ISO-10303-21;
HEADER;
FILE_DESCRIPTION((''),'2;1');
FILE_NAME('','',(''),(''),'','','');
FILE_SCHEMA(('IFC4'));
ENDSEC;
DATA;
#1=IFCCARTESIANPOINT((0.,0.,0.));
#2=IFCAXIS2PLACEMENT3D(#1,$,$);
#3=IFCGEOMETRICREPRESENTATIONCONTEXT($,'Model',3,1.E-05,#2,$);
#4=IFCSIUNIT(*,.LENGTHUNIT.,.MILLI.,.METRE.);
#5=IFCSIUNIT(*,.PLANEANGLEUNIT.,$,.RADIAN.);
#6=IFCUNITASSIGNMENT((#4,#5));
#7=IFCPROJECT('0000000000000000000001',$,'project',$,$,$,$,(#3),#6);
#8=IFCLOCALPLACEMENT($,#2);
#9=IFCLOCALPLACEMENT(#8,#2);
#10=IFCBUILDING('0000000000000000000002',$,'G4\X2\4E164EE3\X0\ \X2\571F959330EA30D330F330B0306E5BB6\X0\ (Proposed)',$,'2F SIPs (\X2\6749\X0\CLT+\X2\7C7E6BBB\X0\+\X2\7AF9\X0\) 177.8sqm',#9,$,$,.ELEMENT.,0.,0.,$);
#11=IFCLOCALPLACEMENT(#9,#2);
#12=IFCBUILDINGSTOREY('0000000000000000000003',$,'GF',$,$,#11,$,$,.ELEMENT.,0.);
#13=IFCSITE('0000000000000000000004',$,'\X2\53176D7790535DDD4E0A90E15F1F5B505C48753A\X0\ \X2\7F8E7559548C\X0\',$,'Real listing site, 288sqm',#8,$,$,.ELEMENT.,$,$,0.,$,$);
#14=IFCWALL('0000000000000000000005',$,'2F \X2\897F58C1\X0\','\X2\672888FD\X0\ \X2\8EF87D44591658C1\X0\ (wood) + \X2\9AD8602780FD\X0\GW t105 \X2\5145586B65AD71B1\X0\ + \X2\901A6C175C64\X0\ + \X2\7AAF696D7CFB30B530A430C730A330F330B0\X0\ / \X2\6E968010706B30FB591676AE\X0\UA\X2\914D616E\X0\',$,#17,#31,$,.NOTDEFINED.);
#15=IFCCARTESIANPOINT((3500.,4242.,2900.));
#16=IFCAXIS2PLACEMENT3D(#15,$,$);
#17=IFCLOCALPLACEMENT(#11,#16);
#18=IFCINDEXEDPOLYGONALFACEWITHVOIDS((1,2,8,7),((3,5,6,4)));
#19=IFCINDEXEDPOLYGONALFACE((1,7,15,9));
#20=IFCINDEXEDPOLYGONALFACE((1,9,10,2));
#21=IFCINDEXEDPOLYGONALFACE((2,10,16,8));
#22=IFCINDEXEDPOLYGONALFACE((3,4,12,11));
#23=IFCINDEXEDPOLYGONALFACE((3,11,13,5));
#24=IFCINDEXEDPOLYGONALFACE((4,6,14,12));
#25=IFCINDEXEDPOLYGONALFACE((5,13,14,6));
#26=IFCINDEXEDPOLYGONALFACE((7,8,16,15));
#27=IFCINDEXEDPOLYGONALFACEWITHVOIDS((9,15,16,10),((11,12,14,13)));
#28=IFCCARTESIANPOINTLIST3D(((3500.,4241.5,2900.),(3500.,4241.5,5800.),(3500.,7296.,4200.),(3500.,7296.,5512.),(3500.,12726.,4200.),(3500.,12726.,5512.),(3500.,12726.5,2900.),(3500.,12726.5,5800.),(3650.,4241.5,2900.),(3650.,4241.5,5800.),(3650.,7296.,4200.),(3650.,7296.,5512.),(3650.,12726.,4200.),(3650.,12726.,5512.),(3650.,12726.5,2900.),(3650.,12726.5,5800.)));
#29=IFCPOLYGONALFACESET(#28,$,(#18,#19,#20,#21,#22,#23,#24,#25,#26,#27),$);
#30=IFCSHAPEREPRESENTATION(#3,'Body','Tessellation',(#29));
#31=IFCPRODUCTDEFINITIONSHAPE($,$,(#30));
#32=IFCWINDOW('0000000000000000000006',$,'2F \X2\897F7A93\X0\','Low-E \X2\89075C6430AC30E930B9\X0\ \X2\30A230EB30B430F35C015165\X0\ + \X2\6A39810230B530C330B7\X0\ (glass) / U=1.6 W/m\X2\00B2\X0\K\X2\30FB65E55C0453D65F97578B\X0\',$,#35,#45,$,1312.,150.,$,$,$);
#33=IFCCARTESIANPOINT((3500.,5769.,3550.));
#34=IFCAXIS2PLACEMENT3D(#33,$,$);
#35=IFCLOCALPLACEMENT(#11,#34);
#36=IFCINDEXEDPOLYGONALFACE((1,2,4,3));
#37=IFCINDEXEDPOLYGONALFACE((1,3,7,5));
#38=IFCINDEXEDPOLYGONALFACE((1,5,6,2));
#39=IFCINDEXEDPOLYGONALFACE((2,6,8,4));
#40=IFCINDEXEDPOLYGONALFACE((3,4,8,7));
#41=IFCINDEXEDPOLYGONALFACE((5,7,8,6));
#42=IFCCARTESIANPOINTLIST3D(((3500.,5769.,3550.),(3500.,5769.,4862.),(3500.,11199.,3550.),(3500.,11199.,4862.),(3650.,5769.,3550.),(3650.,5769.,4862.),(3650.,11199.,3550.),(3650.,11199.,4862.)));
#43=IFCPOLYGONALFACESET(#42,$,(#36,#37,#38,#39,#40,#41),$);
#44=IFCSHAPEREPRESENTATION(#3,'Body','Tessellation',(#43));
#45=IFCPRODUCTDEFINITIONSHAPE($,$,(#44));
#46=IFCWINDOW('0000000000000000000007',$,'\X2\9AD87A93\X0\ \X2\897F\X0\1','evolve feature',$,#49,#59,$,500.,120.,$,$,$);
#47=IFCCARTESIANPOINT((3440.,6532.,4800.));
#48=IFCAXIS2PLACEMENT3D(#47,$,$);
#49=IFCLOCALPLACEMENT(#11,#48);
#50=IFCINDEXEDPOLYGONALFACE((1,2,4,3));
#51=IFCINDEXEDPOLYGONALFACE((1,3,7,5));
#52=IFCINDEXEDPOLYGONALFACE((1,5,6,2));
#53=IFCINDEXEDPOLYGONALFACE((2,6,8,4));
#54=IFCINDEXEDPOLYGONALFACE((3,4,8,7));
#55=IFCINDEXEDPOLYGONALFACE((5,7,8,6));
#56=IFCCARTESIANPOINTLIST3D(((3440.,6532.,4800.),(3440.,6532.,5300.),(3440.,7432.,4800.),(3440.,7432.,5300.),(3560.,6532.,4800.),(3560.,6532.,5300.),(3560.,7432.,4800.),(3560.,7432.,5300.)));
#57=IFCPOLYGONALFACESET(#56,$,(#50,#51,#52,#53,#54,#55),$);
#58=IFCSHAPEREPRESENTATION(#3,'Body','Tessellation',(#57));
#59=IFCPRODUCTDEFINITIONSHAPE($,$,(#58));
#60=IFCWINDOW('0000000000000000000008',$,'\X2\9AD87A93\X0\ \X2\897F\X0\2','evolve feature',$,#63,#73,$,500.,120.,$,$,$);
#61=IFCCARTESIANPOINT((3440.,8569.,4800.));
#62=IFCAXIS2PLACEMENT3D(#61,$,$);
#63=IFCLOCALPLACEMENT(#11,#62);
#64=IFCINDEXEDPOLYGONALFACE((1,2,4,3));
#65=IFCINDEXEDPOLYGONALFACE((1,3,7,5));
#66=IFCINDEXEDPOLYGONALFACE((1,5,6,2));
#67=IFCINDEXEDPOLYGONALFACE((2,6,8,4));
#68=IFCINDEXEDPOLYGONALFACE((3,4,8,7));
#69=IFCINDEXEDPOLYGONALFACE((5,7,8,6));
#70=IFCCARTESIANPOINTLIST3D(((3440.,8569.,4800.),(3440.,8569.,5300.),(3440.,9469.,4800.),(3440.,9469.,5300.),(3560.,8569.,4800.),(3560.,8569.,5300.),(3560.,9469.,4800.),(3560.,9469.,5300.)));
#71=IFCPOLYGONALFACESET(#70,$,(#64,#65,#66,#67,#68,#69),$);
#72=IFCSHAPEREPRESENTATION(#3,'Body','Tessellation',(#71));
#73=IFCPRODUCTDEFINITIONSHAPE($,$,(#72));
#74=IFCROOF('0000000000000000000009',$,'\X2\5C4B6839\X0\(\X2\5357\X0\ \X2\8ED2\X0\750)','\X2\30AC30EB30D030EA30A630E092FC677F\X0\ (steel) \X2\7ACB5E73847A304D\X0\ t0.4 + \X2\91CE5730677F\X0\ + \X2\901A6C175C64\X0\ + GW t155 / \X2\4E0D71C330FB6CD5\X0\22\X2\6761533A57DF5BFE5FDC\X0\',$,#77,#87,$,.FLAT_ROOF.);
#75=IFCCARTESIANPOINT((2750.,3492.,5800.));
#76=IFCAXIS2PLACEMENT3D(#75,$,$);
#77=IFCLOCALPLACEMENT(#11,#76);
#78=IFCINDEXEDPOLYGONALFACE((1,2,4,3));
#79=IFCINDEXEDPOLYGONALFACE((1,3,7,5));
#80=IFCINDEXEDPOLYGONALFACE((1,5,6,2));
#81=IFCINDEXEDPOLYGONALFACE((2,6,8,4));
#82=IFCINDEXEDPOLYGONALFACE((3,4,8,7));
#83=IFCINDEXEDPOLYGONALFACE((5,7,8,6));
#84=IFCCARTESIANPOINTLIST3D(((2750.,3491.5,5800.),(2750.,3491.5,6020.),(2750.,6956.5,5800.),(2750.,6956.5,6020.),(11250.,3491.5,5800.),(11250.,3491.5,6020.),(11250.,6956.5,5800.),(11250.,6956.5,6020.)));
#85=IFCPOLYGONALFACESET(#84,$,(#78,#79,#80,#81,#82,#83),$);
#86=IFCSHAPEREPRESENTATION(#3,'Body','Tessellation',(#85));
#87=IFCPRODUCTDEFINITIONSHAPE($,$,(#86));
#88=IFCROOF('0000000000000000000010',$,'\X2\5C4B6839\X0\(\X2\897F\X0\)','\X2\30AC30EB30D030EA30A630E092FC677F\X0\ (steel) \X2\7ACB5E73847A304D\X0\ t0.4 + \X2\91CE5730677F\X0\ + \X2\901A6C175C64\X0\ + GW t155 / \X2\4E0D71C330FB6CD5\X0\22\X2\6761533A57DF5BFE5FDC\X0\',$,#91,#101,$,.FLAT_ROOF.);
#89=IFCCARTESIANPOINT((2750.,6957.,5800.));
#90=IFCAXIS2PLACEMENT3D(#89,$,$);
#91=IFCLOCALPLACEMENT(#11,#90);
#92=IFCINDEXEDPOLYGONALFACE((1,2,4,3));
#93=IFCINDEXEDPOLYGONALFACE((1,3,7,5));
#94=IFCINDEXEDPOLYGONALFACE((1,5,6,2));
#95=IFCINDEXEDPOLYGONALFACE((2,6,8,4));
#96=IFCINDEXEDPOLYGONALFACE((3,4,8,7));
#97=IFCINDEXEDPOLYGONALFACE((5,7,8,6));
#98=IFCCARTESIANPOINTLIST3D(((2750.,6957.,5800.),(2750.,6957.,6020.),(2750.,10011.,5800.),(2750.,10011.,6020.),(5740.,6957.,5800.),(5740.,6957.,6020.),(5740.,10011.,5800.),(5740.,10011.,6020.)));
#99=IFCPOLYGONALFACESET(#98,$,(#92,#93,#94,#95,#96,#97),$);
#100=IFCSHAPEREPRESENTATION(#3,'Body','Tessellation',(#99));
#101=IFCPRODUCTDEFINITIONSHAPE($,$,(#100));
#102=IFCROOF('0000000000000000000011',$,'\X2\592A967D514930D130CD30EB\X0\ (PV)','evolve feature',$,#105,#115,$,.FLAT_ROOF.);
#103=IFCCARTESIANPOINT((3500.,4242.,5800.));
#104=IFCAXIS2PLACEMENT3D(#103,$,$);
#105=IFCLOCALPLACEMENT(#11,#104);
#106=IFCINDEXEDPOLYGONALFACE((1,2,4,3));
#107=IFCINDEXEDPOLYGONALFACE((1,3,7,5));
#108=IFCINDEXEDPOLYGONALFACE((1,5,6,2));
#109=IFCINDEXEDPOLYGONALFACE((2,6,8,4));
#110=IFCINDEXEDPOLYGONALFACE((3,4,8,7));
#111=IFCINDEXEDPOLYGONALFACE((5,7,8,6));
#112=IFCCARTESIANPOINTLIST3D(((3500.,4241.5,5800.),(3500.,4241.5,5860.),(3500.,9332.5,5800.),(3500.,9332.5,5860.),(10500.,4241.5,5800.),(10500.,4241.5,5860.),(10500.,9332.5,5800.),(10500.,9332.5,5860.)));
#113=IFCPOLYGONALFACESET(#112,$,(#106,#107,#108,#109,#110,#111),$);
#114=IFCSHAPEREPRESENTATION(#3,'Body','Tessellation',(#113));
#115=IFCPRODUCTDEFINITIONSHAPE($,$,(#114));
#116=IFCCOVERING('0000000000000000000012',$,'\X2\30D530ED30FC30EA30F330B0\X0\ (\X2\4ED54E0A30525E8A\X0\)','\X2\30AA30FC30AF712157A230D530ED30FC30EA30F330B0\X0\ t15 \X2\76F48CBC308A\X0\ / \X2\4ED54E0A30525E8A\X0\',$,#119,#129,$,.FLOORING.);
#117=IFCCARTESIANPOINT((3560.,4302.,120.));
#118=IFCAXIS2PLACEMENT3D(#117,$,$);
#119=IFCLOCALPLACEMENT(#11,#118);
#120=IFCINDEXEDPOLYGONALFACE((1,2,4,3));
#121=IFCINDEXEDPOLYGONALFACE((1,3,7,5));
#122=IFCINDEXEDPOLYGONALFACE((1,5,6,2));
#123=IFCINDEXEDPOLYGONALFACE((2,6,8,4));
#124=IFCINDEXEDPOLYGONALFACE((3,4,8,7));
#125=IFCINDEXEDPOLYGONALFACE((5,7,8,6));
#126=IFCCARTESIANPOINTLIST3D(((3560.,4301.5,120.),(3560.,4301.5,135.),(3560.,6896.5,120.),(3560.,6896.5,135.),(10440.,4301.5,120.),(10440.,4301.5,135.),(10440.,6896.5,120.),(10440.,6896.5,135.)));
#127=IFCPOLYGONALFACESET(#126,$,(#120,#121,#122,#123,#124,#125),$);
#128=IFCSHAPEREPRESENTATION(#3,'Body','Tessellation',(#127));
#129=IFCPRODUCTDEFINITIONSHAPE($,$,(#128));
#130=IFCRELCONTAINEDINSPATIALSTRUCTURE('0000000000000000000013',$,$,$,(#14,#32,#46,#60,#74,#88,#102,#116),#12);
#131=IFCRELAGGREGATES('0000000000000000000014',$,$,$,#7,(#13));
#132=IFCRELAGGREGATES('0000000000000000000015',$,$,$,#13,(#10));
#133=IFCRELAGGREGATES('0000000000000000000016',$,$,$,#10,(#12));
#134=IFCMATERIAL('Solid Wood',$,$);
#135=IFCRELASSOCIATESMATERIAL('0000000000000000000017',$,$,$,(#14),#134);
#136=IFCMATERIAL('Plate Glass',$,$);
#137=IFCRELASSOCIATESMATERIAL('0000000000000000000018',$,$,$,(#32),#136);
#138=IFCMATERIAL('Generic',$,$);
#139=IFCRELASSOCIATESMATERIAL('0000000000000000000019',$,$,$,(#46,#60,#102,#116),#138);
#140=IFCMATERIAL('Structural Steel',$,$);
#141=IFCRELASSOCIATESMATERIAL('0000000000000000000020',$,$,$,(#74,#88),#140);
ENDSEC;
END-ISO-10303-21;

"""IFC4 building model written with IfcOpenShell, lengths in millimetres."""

from ifc_helpers import new_model, si_unit, frame, frame_2d, origin, place, context, project, spatial, rectangle, extrude, material, element, fill, save


model = new_model("IFC4")

# Units and contexts
model_context = context("Model", 3, precision=1e-05, world=origin())
ifc_project = project(units=[si_unit("LENGTHUNIT", "METRE", prefix="MILLI"), si_unit("PLANEANGLEUNIT", "RADIAN")], contexts=[model_context])

# Site, building, storey
site_placement = place(None, origin())
site = spatial("IfcSite", under=ifc_project, at=site_placement, Name="北海道川上郡弟子屈町 美留和", ObjectType="Real listing site, 288sqm", CompositionType="ELEMENT", RefElevation=0.0)
building_placement = place(site_placement, origin())
building = spatial("IfcBuilding", under=site, at=building_placement, Name="G4世代 土間リビングの家 (Proposed)", ObjectType="2F SIPs (杉CLT+籾殻+竹) 177.8sqm", CompositionType="ELEMENT", ElevationOfRefHeight=0.0, ElevationOfTerrain=0.0)
storey_placement = place(building_placement, origin())
storey = spatial("IfcBuildingStorey", under=building, at=storey_placement, Name="GF", CompositionType="ELEMENT", Elevation=0.0)

# Shared definitions
ifc_material_1 = material(Name="Solid Wood")
ifc_material_2 = material(Name="Generic")

# Shared definitions
ifc_material_3 = material(Name="Plate Glass")

# Wall, openings, windows
wall_1_placement = place(storey_placement, frame((3500.0, 4242.0, 2900.0)))
wall_1 = element("IfcWall", 1, at=wall_1_placement, inside=storey, material=ifc_material_1, Name="2F 西壁", Description="木製 軸組外壁 (wood) + 高性能GW t105 充填断熱 + 通気層 + 窯業系サイディング / 準耐火・外皮UA配慮", PredefinedType="NOTDEFINED", context=model_context, shape_type="SweptSolid", body=[
    extrude(rectangle(XDim=150.0, YDim=8485.0, at=frame_2d((75.0, 4242.0))), frame((3500.0, 4242.0, 2900.0)), (0.0, 0.0, 1.0), 2900.0),
])
opening_1_placement = place(storey_placement, frame((3500.0, 5769.0, 3550.0)))
opening_1 = element("IfcOpeningElement", 2, at=opening_1_placement, cuts=wall_1, PredefinedType="NOTDEFINED", context=model_context, shape_type="SweptSolid", body=[
    extrude(rectangle(XDim=150.0, YDim=5430.0, at=frame_2d((75.0, 2715.0))), frame((3500.0, 5769.0, 3550.0)), (0.0, 0.0, 1.0), 1312.0),
])
opening_2_placement = place(storey_placement, frame((3440.0, 6532.0, 4800.0)))
opening_2 = element("IfcOpeningElement", 3, at=opening_2_placement, cuts=wall_1, PredefinedType="NOTDEFINED", context=model_context, shape_type="SweptSolid", body=[
    extrude(rectangle(XDim=120.0, YDim=900.0, at=frame_2d((60.0, 450.0))), frame((3440.0, 6532.0, 4800.0)), (0.0, 0.0, 1.0), 500.0),
])
opening_3_placement = place(storey_placement, frame((3440.0, 8569.0, 4800.0)))
opening_3 = element("IfcOpeningElement", 4, at=opening_3_placement, cuts=wall_1, PredefinedType="NOTDEFINED", context=model_context, shape_type="SweptSolid", body=[
    extrude(rectangle(XDim=120.0, YDim=900.0, at=frame_2d((60.0, 450.0))), frame((3440.0, 8569.0, 4800.0)), (0.0, 0.0, 1.0), 500.0),
])
window_1_placement = place(storey_placement, frame((3500.0, 5769.0, 3550.0)))
window_1 = element("IfcWindow", 5, at=window_1_placement, inside=storey, material=ifc_material_3, Name="2F 西窓", Description="Low-E 複層ガラス アルゴン封入 + 樹脂サッシ (glass) / U=1.6 W/m²K・日射取得型", OverallHeight=1312.0, OverallWidth=150.0, context=model_context, shape_type="SweptSolid", body=[
    extrude(rectangle(XDim=150.0, YDim=5430.0, at=frame_2d((75.0, 2715.0))), frame((3500.0, 5769.0, 3550.0)), (0.0, 0.0, 1.0), 1312.0),
])
fill(opening_1, window_1)
window_2_placement = place(storey_placement, frame((3440.0, 6532.0, 4800.0)))
window_2 = element("IfcWindow", 6, at=window_2_placement, inside=storey, material=ifc_material_2, Name="高窓 西1", Description="evolve feature", OverallHeight=500.0, OverallWidth=120.0, context=model_context, shape_type="SweptSolid", body=[
    extrude(rectangle(XDim=120.0, YDim=900.0, at=frame_2d((60.0, 450.0))), frame((3440.0, 6532.0, 4800.0)), (0.0, 0.0, 1.0), 500.0),
])
fill(opening_2, window_2)
window_3_placement = place(storey_placement, frame((3440.0, 8569.0, 4800.0)))
window_3 = element("IfcWindow", 7, at=window_3_placement, inside=storey, material=ifc_material_2, Name="高窓 西2", Description="evolve feature", OverallHeight=500.0, OverallWidth=120.0, context=model_context, shape_type="SweptSolid", body=[
    extrude(rectangle(XDim=120.0, YDim=900.0, at=frame_2d((60.0, 450.0))), frame((3440.0, 8569.0, 4800.0)), (0.0, 0.0, 1.0), 500.0),
])
fill(opening_3, window_3)

# Roofs
ifc_material_4 = material(Name="Structural Steel")
roof_1_placement = place(storey_placement, frame((2750.0, 3492.0, 5800.0)))
element("IfcRoof", 8, at=roof_1_placement, inside=storey, material=ifc_material_4, Name="屋根(南 軒750)", Description="ガルバリウム鋼板 (steel) 立平葺き t0.4 + 野地板 + 通気層 + GW t155 / 不燃・法22条区域対応", PredefinedType="FLAT_ROOF", context=model_context, shape_type="SweptSolid", body=[
    extrude(rectangle(XDim=8500.0, YDim=3465.0, at=frame_2d((4250.0, 1732.0))), frame((2750.0, 3492.0, 5800.0)), (0.0, 0.0, 1.0), 220.0),
])
roof_2_placement = place(storey_placement, frame((2750.0, 6957.0, 5800.0)))
element("IfcRoof", 9, at=roof_2_placement, inside=storey, material=ifc_material_4, Name="屋根(西)", Description="ガルバリウム鋼板 (steel) 立平葺き t0.4 + 野地板 + 通気層 + GW t155 / 不燃・法22条区域対応", PredefinedType="FLAT_ROOF", context=model_context, shape_type="SweptSolid", body=[
    extrude(rectangle(XDim=2990.0, YDim=3054.0, at=frame_2d((1495.0, 1527.0))), frame((2750.0, 6957.0, 5800.0)), (0.0, 0.0, 1.0), 220.0),
])
roof_3_placement = place(storey_placement, frame((3500.0, 4242.0, 5800.0)))
element("IfcRoof", 10, at=roof_3_placement, inside=storey, material=ifc_material_2, Name="太陽光パネル (PV)", Description="evolve feature", PredefinedType="FLAT_ROOF", context=model_context, shape_type="SweptSolid", body=[
    extrude(rectangle(XDim=7000.0, YDim=5091.0, at=frame_2d((3500.0, 2545.0))), frame((3500.0, 4242.0, 5800.0)), (0.0, 0.0, 1.0), 60.0),
])

# Covering
covering_placement = place(storey_placement, frame((3560.0, 4302.0, 120.0)))
element("IfcCovering", 11, at=covering_placement, inside=storey, material=ifc_material_2, Name="フローリング (仕上げ床)", Description="オーク無垢フローリング t15 直貼り / 仕上げ床", PredefinedType="FLOORING", context=model_context, shape_type="SweptSolid", body=[
    extrude(rectangle(XDim=6880.0, YDim=2595.0, at=frame_2d((3440.0, 1297.0))), frame((3560.0, 4302.0, 120.0)), (0.0, 0.0, 1.0), 15.0),
])

save(model, "model.ifc")
